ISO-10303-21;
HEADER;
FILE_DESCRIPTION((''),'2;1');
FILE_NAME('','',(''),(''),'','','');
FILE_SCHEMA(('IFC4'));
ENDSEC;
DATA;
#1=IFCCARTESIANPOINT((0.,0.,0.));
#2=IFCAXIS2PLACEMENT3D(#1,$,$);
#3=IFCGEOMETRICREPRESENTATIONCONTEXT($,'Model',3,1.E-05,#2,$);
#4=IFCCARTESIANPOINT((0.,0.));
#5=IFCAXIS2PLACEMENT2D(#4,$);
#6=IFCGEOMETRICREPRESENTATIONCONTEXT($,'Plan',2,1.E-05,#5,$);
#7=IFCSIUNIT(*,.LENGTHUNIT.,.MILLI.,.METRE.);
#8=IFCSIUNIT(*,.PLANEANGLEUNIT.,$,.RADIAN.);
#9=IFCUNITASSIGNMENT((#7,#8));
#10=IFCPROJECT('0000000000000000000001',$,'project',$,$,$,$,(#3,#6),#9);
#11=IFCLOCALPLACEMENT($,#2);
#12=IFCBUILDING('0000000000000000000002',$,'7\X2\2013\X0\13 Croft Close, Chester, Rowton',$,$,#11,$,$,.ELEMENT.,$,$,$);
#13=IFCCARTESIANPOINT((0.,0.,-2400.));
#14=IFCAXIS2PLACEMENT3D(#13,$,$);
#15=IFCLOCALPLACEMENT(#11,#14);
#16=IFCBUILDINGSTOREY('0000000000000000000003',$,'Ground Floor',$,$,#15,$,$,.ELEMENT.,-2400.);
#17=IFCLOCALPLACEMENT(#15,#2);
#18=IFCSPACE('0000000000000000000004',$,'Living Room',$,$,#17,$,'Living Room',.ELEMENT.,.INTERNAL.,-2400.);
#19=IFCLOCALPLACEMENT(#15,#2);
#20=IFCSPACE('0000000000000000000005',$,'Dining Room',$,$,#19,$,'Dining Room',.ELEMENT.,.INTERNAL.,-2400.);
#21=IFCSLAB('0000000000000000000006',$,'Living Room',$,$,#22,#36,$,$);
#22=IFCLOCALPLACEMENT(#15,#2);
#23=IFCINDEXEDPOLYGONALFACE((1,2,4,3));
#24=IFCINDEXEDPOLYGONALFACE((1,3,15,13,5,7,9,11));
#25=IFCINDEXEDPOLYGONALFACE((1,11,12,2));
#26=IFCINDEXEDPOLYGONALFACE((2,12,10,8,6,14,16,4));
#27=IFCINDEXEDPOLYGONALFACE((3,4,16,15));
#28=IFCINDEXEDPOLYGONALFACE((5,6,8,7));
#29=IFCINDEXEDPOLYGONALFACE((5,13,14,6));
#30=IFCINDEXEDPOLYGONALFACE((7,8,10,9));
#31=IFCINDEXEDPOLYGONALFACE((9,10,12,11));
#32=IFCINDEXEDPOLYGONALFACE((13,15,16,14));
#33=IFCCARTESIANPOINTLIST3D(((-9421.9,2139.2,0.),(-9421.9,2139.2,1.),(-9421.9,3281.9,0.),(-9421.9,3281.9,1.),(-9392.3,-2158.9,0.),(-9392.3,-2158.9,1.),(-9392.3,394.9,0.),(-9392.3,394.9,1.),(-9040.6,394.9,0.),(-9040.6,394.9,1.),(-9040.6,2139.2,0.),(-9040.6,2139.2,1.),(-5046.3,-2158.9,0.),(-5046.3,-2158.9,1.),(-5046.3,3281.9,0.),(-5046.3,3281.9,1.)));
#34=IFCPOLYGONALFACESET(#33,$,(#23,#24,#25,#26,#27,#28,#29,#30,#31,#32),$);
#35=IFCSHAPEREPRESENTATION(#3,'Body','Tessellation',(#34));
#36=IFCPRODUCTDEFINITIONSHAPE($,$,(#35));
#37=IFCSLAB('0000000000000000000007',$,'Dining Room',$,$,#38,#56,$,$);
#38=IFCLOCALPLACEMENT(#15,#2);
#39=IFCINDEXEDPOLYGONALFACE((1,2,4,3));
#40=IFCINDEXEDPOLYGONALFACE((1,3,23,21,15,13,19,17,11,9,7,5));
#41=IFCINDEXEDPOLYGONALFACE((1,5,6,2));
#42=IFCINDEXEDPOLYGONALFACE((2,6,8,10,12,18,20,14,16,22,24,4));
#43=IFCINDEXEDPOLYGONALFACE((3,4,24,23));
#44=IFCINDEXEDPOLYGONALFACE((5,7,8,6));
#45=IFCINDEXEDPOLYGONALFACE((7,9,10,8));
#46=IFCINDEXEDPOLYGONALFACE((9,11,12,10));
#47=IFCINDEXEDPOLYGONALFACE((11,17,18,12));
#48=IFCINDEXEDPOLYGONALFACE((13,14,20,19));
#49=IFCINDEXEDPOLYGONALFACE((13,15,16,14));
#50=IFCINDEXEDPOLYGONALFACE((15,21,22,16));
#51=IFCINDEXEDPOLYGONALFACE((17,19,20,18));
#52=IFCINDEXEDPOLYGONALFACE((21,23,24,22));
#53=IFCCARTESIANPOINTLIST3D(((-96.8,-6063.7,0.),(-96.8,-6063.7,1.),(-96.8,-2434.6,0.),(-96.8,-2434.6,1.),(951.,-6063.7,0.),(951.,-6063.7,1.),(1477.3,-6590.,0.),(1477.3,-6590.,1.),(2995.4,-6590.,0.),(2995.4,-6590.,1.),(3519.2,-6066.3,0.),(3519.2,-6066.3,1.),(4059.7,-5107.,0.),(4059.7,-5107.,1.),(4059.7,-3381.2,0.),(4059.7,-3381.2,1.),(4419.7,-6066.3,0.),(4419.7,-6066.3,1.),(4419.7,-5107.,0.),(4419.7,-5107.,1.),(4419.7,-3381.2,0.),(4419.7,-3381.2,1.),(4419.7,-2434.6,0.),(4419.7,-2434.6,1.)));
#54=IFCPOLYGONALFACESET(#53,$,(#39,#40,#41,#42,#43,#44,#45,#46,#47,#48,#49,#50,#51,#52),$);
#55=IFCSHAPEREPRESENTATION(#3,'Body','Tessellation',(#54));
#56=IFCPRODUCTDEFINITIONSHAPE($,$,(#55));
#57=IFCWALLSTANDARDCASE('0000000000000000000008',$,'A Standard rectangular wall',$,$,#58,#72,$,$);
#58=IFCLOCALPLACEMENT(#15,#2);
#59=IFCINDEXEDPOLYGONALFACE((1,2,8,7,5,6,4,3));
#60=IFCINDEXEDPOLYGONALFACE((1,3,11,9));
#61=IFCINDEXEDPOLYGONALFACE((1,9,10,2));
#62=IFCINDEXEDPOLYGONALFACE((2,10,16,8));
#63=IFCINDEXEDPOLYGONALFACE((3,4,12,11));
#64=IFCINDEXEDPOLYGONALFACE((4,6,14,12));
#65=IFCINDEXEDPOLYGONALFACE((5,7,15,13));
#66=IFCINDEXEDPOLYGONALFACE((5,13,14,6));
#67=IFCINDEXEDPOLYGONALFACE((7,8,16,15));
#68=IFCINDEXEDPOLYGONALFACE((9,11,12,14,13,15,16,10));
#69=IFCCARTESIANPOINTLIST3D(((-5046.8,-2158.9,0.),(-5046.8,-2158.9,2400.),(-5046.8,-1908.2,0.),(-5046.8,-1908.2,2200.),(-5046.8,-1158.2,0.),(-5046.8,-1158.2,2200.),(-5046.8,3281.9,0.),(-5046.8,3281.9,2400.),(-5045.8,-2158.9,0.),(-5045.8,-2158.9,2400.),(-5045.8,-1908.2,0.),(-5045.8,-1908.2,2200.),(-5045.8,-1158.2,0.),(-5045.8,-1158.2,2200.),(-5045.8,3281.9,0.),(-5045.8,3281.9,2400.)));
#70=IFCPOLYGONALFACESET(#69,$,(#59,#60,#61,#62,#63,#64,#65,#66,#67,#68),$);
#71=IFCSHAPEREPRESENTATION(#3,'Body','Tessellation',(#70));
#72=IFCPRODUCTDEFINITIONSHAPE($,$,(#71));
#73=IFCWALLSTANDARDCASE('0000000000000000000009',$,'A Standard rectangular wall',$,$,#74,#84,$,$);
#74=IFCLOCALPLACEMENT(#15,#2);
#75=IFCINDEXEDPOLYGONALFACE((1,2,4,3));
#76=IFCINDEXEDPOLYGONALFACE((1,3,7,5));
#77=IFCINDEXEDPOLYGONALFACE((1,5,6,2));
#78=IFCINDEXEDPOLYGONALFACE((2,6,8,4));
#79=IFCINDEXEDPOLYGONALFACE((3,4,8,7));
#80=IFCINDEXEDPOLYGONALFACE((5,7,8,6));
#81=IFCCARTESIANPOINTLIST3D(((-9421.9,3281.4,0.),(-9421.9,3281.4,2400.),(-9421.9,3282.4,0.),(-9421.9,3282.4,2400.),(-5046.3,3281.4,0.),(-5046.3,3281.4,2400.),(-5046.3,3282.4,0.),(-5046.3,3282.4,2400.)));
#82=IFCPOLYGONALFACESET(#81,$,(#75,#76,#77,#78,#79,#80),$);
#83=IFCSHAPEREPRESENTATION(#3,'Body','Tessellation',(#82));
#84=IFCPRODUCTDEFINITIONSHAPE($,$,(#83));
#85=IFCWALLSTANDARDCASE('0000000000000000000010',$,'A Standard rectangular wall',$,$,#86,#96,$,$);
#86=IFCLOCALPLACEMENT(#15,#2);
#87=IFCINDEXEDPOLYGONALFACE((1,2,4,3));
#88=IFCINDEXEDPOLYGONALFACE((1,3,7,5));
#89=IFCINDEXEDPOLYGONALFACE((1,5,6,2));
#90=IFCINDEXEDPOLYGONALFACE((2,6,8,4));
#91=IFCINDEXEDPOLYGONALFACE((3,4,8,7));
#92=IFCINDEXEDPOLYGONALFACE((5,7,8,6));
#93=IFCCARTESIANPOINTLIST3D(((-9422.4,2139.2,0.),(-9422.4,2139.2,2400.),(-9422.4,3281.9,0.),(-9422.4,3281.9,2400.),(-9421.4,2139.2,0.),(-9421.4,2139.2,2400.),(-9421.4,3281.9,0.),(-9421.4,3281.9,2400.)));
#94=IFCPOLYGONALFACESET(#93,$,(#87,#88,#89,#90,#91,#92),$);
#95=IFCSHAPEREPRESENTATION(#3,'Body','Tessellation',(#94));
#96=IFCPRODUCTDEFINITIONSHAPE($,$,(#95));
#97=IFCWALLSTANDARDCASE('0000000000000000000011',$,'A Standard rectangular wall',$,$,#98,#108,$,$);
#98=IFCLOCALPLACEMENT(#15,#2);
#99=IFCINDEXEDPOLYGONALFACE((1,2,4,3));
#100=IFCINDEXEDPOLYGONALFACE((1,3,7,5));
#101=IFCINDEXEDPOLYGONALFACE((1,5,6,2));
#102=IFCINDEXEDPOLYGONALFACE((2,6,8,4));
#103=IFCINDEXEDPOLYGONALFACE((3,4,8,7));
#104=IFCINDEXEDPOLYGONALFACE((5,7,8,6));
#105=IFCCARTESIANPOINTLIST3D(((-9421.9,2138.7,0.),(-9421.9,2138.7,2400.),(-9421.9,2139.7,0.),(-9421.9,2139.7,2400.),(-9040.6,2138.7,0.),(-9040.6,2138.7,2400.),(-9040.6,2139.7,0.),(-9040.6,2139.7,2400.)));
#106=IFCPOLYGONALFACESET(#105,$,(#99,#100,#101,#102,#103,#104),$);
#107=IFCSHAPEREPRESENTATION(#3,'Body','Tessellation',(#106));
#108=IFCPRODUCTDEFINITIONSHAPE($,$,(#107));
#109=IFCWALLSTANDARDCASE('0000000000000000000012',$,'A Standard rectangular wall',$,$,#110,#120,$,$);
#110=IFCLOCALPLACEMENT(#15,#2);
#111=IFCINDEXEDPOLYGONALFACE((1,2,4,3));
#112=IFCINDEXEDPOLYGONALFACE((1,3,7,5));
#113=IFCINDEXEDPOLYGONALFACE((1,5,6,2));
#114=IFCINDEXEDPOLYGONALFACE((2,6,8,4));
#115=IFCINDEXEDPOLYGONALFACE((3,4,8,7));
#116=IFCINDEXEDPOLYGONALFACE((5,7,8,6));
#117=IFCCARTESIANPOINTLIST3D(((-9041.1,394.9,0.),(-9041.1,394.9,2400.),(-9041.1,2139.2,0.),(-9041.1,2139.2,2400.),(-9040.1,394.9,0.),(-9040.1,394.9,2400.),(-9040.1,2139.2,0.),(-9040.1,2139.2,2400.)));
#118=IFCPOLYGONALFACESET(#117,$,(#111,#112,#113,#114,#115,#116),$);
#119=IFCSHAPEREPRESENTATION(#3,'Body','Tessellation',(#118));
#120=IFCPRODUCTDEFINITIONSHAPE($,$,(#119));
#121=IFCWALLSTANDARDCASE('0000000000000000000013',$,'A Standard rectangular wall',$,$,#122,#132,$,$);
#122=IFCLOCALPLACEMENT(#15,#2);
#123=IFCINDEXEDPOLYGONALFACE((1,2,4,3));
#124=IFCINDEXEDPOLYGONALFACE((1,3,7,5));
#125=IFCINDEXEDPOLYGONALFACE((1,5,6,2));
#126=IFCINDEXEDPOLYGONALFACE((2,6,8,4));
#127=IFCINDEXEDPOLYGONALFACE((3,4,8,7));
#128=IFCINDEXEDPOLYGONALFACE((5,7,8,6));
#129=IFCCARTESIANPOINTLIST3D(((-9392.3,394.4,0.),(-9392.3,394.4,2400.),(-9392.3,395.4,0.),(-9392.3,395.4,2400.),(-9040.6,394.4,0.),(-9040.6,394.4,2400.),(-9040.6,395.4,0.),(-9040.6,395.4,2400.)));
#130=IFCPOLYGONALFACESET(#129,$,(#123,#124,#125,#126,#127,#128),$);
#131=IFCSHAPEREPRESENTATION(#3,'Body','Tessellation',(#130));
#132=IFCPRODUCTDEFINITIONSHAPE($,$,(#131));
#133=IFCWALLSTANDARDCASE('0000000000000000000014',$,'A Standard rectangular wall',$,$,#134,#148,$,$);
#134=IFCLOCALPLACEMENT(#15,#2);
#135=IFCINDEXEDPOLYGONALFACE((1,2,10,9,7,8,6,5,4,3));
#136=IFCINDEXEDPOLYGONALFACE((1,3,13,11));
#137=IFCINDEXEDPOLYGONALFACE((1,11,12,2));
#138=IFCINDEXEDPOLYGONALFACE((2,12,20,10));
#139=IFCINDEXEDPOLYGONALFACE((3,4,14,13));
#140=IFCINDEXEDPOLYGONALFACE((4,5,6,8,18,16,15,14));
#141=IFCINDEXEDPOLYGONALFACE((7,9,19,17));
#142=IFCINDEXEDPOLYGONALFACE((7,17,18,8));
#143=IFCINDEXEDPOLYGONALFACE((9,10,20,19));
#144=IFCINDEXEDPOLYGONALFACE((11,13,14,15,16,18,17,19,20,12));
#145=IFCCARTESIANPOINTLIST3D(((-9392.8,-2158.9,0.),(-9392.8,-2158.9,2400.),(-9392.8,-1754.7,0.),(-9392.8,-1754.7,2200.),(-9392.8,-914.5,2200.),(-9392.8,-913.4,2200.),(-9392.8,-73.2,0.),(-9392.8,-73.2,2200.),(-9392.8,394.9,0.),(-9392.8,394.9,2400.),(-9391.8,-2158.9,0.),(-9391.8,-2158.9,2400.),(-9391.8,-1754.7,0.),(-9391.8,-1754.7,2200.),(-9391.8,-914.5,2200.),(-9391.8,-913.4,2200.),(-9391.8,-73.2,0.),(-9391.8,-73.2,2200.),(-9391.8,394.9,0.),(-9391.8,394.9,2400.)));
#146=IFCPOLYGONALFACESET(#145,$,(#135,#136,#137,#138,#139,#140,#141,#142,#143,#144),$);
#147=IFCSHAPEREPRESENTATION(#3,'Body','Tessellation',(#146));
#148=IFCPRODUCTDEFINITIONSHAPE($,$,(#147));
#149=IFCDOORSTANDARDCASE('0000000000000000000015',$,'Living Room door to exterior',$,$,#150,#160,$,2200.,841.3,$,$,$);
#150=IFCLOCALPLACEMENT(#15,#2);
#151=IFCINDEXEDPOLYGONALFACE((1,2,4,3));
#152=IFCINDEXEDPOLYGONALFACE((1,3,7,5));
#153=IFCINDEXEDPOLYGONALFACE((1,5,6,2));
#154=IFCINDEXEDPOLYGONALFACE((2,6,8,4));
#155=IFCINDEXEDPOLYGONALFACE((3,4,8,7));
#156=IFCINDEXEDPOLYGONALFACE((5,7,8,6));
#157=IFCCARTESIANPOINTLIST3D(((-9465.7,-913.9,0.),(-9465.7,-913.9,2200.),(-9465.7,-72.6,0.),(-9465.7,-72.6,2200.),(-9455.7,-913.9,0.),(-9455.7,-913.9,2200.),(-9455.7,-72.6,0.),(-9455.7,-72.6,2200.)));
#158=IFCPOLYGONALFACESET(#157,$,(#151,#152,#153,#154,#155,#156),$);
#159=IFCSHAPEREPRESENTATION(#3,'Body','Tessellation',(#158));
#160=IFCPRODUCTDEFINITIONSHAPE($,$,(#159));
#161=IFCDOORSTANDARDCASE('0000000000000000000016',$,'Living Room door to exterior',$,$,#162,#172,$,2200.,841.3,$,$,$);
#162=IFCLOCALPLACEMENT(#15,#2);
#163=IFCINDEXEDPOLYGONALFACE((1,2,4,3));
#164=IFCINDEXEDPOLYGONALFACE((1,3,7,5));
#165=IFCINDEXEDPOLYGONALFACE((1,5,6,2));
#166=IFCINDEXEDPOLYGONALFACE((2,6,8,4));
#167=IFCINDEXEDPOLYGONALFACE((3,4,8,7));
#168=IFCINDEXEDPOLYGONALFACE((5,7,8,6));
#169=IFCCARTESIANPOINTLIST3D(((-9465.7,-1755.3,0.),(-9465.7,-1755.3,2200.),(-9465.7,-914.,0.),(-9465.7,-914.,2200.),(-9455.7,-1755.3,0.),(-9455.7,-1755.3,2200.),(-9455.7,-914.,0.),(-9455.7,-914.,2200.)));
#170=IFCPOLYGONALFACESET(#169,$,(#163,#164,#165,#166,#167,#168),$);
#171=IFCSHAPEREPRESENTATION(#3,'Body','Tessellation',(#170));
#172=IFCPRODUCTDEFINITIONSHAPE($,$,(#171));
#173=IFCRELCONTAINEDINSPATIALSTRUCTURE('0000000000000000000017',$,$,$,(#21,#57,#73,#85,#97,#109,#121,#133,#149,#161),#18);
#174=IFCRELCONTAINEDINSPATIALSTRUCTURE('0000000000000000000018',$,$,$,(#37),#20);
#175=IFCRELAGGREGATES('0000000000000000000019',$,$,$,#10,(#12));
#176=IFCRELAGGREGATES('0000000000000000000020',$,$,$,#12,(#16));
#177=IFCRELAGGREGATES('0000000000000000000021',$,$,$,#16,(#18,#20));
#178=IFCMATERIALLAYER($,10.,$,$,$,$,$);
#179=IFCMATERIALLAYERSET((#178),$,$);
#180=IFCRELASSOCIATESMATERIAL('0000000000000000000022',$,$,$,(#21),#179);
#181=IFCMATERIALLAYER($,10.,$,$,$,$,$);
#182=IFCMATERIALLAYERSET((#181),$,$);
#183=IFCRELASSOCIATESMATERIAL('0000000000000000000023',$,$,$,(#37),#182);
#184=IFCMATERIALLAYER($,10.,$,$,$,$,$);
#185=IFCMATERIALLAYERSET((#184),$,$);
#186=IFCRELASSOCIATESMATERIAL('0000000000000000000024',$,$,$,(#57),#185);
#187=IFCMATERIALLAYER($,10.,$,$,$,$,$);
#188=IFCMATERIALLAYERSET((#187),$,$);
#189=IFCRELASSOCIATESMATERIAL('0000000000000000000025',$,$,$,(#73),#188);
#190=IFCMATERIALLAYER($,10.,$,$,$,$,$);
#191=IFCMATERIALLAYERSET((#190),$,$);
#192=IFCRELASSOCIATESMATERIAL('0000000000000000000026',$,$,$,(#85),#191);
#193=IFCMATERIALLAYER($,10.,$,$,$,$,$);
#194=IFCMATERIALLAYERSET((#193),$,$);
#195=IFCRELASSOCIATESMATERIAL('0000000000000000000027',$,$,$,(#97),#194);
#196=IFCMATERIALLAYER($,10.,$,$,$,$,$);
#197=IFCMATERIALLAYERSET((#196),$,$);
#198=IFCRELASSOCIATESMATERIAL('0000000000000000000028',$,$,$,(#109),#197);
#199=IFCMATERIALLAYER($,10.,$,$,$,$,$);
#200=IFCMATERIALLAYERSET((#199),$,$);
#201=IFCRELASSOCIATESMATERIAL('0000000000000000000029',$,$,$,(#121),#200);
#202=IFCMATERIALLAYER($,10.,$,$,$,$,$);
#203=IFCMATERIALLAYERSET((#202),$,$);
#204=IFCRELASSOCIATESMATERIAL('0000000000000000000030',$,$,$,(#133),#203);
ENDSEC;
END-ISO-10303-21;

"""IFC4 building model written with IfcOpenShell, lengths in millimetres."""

from ifc_helpers import new_model, si_unit, frame, origin, origin_2d, place, context, project, spatial, polyline, rectangle, outline, extrude, layer, layer_set, layer_usage, element, fill, save


model = new_model("IFC4")

# Units and contexts
model_context = context("Model", 3, precision=1e-05, world=origin())
plan_context = context("Plan", 2, precision=1e-05, world=origin_2d())
ifc_project = project(units=[si_unit("LENGTHUNIT", "METRE", prefix="MILLI"), si_unit("PLANEANGLEUNIT", "RADIAN")], contexts=[model_context, plan_context])

# Building, storey, space
building_placement = place(None, origin())
building = spatial("IfcBuilding", under=ifc_project, at=building_placement, Name="7–13 Croft Close, Chester, Rowton", CompositionType="ELEMENT")
storey_placement = place(building_placement, frame((0.0, 0.0, -2400.0)))
storey = spatial("IfcBuildingStorey", under=building, at=storey_placement, Name="Ground Floor", CompositionType="ELEMENT", Elevation=-2400.0)
space_1_placement = place(storey_placement, origin())
space_1 = spatial("IfcSpace", under=storey, at=space_1_placement, Name="Living Room", LongName="Living Room", CompositionType="ELEMENT", PredefinedType="INTERNAL", ElevationWithFlooring=-2400.0)

# Slab
ifc_layer_1 = layer(None, 10.0)
ifc_layer_set_1 = layer_set([ifc_layer_1])
ifc_layer_usage_1 = layer_usage(ifc_layer_set_1, "AXIS2", "NEGATIVE", 150.0)
slab_1_placement = place(storey_placement, origin())
element("IfcSlab", 1, at=slab_1_placement, inside=space_1, material=ifc_layer_usage_1, Name="Living Room", context=model_context, shape_type="SweptSolid", body=[
    extrude(outline(polyline([(-5046.3, -2158.9), (-5046.3, 3281.9), (-9421.9, 3281.9), (-9421.9, 2139.2), (-9040.6, 2139.2), (-9040.6, 394.9), (-9392.3, 394.9), (-9392.3, -2158.9), (-5046.3, -2158.9)])), origin(), (0.0, 0.0, 1.0), 1.0),
])

# Shared definitions
space_2_placement = place(storey_placement, origin())
space_2 = spatial("IfcSpace", under=storey, at=space_2_placement, Name="Dining Room", LongName="Dining Room", CompositionType="ELEMENT", PredefinedType="INTERNAL", ElevationWithFlooring=-2400.0)

# Slab
ifc_layer_2 = layer(None, 10.0)
ifc_layer_set_2 = layer_set([ifc_layer_2])
ifc_layer_usage_2 = layer_usage(ifc_layer_set_2, "AXIS2", "NEGATIVE", 150.0)
slab_2_placement = place(storey_placement, origin())
element("IfcSlab", 2, at=slab_2_placement, inside=space_2, material=ifc_layer_usage_2, Name="Dining Room", context=model_context, shape_type="SweptSolid", body=[
    extrude(outline(polyline([(4419.7, -2434.6), (-96.8, -2434.6), (-96.8, -6063.7), (951.0, -6063.7), (1477.3, -6590.0), (2995.4, -6590.0), (3519.2, -6066.3), (4419.7, -6066.3), (4419.7, -5107.0), (4059.7, -5107.0), (4059.7, -3381.2), (4419.7, -3381.2), (4419.7, -2434.6)])), origin(), (0.0, 0.0, 1.0), 1.0),
])

# Wall, opening
ifc_layer_3 = layer(None, 10.0)
ifc_layer_set_3 = layer_set([ifc_layer_3])
ifc_layer_usage_3 = layer_usage(ifc_layer_set_3, "AXIS2", "NEGATIVE", 150.0)
wall_1_placement = place(storey_placement, origin())
wall_1 = element("IfcWallStandardCase", 3, at=wall_1_placement, inside=space_1, material=ifc_layer_usage_3, Name="A Standard rectangular wall", context=model_context, shape_type="SweptSolid", body=[
    extrude(rectangle(XDim=1.0, YDim=5440.8, at=origin_2d()), frame((-5046.3, 561.5, 0.0), x_axis=(-1.0, 0.0, 0.0)), (0.0, 0.0, 1.0), 2400.0),
])
opening_1_placement = place(storey_placement, origin())
element("IfcOpeningElement", 4, at=opening_1_placement, cuts=wall_1, context=model_context, shape_type="SweptSolid", body=[
    extrude(rectangle(XDim=10.0, YDim=750.0, at=origin_2d()), frame((-5046.3, -1533.2, 0.0), x_axis=(1.0, 0.0, 0.0)), (0.0, 0.0, 1.0), 2200.0),
])

# Walls
ifc_layer_4 = layer(None, 10.0)
ifc_layer_set_4 = layer_set([ifc_layer_4])
ifc_layer_usage_4 = layer_usage(ifc_layer_set_4, "AXIS2", "NEGATIVE", 150.0)
wall_2_placement = place(storey_placement, origin())
element("IfcWallStandardCase", 5, at=wall_2_placement, inside=space_1, material=ifc_layer_usage_4, Name="A Standard rectangular wall", context=model_context, shape_type="SweptSolid", body=[
    extrude(rectangle(XDim=1.0, YDim=4375.6, at=origin_2d()), frame((-7234.1, 3281.9, 0.0), x_axis=(0.0, -1.0, 0.0)), (0.0, 0.0, 1.0), 2400.0),
])
ifc_layer_5 = layer(None, 10.0)
ifc_layer_set_5 = layer_set([ifc_layer_5])
ifc_layer_usage_5 = layer_usage(ifc_layer_set_5, "AXIS2", "NEGATIVE", 150.0)
wall_3_placement = place(storey_placement, origin())
element("IfcWallStandardCase", 6, at=wall_3_placement, inside=space_1, material=ifc_layer_usage_5, Name="A Standard rectangular wall", context=model_context, shape_type="SweptSolid", body=[
    extrude(rectangle(XDim=1.0, YDim=1142.7, at=origin_2d()), frame((-9421.9, 2710.5, 0.0), x_axis=(1.0, 0.0, 0.0)), (0.0, 0.0, 1.0), 2400.0),
])
ifc_layer_6 = layer(None, 10.0)
ifc_layer_set_6 = layer_set([ifc_layer_6])
ifc_layer_usage_6 = layer_usage(ifc_layer_set_6, "AXIS2", "NEGATIVE", 150.0)
wall_4_placement = place(storey_placement, origin())
element("IfcWallStandardCase", 7, at=wall_4_placement, inside=space_1, material=ifc_layer_usage_6, Name="A Standard rectangular wall", context=model_context, shape_type="SweptSolid", body=[
    extrude(rectangle(XDim=1.0, YDim=381.3, at=origin_2d()), frame((-9231.2, 2139.2, 0.0), x_axis=(0.0, 1.0, 0.0)), (0.0, 0.0, 1.0), 2400.0),
])
ifc_layer_7 = layer(None, 10.0)
ifc_layer_set_7 = layer_set([ifc_layer_7])
ifc_layer_usage_7 = layer_usage(ifc_layer_set_7, "AXIS2", "NEGATIVE", 150.0)
wall_5_placement = place(storey_placement, origin())
element("IfcWallStandardCase", 8, at=wall_5_placement, inside=space_1, material=ifc_layer_usage_7, Name="A Standard rectangular wall", context=model_context, shape_type="SweptSolid", body=[
    extrude(rectangle(XDim=1.0, YDim=1744.3, at=origin_2d()), frame((-9040.6, 1267.0, 0.0), x_axis=(1.0, 0.0, 0.0)), (0.0, 0.0, 1.0), 2400.0),
])
ifc_layer_8 = layer(None, 10.0)
ifc_layer_set_8 = layer_set([ifc_layer_8])
ifc_layer_usage_8 = layer_usage(ifc_layer_set_8, "AXIS2", "NEGATIVE", 150.0)
wall_6_placement = place(storey_placement, origin())
element("IfcWallStandardCase", 9, at=wall_6_placement, inside=space_1, material=ifc_layer_usage_8, Name="A Standard rectangular wall", context=model_context, shape_type="SweptSolid", body=[
    extrude(rectangle(XDim=1.0, YDim=351.7, at=origin_2d()), frame((-9216.4, 394.9, 0.0), x_axis=(0.0, -1.0, 0.0)), (0.0, 0.0, 1.0), 2400.0),
])

# Wall, openings, doors
ifc_layer_9 = layer(None, 10.0)
ifc_layer_set_9 = layer_set([ifc_layer_9])
ifc_layer_usage_9 = layer_usage(ifc_layer_set_9, "AXIS2", "NEGATIVE", 150.0)
wall_7_placement = place(storey_placement, origin())
wall_7 = element("IfcWallStandardCase", 10, at=wall_7_placement, inside=space_1, material=ifc_layer_usage_9, Name="A Standard rectangular wall", context=model_context, shape_type="SweptSolid", body=[
    extrude(rectangle(XDim=1.0, YDim=2553.8, at=origin_2d()), frame((-9392.3, -882.0, 0.0), x_axis=(1.0, 0.0, 0.0)), (0.0, 0.0, 1.0), 2400.0),
])
opening_2_placement = place(storey_placement, origin())
opening_2 = element("IfcOpeningElement", 11, at=opening_2_placement, cuts=wall_7, context=model_context, shape_type="SweptSolid", body=[
    extrude(rectangle(XDim=10.0, YDim=841.3, at=origin_2d()), frame((-9392.3, -493.8, 0.0), x_axis=(1.0, 0.0, 0.0)), (0.0, 0.0, 1.0), 2200.0),
])
opening_3_placement = place(storey_placement, origin())
opening_3 = element("IfcOpeningElement", 12, at=opening_3_placement, cuts=wall_7, context=model_context, shape_type="SweptSolid", body=[
    extrude(rectangle(XDim=10.0, YDim=841.3, at=origin_2d()), frame((-9392.3, -1334.0, 0.0), x_axis=(1.0, 0.0, 0.0)), (0.0, 0.0, 1.0), 2200.0),
])
door_1_placement = place(storey_placement, frame((-68.4, 0.5, 0.0)))
door_1 = element("IfcDoorStandardCase", 13, at=door_1_placement, inside=space_1, Name="Living Room door to exterior", OverallHeight=2200.0, OverallWidth=841.3, context=model_context, shape_type="SweptSolid", body=[
    extrude(rectangle(XDim=10.0, YDim=841.3, at=origin_2d()), frame((-9392.3, -493.8, 0.0), x_axis=(1.0, 0.0, 0.0)), (0.0, 0.0, 1.0), 2200.0),
])
fill(opening_2, door_1)
door_2_placement = place(storey_placement, frame((-68.4, -0.7, 0.0)))
door_2 = element("IfcDoorStandardCase", 14, at=door_2_placement, inside=space_1, Name="Living Room door to exterior", OverallHeight=2200.0, OverallWidth=841.3, context=model_context, shape_type="SweptSolid", body=[
    extrude(rectangle(XDim=10.0, YDim=841.3, at=origin_2d()), frame((-9392.3, -1334.0, 0.0), x_axis=(1.0, 0.0, 0.0)), (0.0, 0.0, 1.0), 2200.0),
])
fill(opening_3, door_2)

save(model, "model.ifc")
